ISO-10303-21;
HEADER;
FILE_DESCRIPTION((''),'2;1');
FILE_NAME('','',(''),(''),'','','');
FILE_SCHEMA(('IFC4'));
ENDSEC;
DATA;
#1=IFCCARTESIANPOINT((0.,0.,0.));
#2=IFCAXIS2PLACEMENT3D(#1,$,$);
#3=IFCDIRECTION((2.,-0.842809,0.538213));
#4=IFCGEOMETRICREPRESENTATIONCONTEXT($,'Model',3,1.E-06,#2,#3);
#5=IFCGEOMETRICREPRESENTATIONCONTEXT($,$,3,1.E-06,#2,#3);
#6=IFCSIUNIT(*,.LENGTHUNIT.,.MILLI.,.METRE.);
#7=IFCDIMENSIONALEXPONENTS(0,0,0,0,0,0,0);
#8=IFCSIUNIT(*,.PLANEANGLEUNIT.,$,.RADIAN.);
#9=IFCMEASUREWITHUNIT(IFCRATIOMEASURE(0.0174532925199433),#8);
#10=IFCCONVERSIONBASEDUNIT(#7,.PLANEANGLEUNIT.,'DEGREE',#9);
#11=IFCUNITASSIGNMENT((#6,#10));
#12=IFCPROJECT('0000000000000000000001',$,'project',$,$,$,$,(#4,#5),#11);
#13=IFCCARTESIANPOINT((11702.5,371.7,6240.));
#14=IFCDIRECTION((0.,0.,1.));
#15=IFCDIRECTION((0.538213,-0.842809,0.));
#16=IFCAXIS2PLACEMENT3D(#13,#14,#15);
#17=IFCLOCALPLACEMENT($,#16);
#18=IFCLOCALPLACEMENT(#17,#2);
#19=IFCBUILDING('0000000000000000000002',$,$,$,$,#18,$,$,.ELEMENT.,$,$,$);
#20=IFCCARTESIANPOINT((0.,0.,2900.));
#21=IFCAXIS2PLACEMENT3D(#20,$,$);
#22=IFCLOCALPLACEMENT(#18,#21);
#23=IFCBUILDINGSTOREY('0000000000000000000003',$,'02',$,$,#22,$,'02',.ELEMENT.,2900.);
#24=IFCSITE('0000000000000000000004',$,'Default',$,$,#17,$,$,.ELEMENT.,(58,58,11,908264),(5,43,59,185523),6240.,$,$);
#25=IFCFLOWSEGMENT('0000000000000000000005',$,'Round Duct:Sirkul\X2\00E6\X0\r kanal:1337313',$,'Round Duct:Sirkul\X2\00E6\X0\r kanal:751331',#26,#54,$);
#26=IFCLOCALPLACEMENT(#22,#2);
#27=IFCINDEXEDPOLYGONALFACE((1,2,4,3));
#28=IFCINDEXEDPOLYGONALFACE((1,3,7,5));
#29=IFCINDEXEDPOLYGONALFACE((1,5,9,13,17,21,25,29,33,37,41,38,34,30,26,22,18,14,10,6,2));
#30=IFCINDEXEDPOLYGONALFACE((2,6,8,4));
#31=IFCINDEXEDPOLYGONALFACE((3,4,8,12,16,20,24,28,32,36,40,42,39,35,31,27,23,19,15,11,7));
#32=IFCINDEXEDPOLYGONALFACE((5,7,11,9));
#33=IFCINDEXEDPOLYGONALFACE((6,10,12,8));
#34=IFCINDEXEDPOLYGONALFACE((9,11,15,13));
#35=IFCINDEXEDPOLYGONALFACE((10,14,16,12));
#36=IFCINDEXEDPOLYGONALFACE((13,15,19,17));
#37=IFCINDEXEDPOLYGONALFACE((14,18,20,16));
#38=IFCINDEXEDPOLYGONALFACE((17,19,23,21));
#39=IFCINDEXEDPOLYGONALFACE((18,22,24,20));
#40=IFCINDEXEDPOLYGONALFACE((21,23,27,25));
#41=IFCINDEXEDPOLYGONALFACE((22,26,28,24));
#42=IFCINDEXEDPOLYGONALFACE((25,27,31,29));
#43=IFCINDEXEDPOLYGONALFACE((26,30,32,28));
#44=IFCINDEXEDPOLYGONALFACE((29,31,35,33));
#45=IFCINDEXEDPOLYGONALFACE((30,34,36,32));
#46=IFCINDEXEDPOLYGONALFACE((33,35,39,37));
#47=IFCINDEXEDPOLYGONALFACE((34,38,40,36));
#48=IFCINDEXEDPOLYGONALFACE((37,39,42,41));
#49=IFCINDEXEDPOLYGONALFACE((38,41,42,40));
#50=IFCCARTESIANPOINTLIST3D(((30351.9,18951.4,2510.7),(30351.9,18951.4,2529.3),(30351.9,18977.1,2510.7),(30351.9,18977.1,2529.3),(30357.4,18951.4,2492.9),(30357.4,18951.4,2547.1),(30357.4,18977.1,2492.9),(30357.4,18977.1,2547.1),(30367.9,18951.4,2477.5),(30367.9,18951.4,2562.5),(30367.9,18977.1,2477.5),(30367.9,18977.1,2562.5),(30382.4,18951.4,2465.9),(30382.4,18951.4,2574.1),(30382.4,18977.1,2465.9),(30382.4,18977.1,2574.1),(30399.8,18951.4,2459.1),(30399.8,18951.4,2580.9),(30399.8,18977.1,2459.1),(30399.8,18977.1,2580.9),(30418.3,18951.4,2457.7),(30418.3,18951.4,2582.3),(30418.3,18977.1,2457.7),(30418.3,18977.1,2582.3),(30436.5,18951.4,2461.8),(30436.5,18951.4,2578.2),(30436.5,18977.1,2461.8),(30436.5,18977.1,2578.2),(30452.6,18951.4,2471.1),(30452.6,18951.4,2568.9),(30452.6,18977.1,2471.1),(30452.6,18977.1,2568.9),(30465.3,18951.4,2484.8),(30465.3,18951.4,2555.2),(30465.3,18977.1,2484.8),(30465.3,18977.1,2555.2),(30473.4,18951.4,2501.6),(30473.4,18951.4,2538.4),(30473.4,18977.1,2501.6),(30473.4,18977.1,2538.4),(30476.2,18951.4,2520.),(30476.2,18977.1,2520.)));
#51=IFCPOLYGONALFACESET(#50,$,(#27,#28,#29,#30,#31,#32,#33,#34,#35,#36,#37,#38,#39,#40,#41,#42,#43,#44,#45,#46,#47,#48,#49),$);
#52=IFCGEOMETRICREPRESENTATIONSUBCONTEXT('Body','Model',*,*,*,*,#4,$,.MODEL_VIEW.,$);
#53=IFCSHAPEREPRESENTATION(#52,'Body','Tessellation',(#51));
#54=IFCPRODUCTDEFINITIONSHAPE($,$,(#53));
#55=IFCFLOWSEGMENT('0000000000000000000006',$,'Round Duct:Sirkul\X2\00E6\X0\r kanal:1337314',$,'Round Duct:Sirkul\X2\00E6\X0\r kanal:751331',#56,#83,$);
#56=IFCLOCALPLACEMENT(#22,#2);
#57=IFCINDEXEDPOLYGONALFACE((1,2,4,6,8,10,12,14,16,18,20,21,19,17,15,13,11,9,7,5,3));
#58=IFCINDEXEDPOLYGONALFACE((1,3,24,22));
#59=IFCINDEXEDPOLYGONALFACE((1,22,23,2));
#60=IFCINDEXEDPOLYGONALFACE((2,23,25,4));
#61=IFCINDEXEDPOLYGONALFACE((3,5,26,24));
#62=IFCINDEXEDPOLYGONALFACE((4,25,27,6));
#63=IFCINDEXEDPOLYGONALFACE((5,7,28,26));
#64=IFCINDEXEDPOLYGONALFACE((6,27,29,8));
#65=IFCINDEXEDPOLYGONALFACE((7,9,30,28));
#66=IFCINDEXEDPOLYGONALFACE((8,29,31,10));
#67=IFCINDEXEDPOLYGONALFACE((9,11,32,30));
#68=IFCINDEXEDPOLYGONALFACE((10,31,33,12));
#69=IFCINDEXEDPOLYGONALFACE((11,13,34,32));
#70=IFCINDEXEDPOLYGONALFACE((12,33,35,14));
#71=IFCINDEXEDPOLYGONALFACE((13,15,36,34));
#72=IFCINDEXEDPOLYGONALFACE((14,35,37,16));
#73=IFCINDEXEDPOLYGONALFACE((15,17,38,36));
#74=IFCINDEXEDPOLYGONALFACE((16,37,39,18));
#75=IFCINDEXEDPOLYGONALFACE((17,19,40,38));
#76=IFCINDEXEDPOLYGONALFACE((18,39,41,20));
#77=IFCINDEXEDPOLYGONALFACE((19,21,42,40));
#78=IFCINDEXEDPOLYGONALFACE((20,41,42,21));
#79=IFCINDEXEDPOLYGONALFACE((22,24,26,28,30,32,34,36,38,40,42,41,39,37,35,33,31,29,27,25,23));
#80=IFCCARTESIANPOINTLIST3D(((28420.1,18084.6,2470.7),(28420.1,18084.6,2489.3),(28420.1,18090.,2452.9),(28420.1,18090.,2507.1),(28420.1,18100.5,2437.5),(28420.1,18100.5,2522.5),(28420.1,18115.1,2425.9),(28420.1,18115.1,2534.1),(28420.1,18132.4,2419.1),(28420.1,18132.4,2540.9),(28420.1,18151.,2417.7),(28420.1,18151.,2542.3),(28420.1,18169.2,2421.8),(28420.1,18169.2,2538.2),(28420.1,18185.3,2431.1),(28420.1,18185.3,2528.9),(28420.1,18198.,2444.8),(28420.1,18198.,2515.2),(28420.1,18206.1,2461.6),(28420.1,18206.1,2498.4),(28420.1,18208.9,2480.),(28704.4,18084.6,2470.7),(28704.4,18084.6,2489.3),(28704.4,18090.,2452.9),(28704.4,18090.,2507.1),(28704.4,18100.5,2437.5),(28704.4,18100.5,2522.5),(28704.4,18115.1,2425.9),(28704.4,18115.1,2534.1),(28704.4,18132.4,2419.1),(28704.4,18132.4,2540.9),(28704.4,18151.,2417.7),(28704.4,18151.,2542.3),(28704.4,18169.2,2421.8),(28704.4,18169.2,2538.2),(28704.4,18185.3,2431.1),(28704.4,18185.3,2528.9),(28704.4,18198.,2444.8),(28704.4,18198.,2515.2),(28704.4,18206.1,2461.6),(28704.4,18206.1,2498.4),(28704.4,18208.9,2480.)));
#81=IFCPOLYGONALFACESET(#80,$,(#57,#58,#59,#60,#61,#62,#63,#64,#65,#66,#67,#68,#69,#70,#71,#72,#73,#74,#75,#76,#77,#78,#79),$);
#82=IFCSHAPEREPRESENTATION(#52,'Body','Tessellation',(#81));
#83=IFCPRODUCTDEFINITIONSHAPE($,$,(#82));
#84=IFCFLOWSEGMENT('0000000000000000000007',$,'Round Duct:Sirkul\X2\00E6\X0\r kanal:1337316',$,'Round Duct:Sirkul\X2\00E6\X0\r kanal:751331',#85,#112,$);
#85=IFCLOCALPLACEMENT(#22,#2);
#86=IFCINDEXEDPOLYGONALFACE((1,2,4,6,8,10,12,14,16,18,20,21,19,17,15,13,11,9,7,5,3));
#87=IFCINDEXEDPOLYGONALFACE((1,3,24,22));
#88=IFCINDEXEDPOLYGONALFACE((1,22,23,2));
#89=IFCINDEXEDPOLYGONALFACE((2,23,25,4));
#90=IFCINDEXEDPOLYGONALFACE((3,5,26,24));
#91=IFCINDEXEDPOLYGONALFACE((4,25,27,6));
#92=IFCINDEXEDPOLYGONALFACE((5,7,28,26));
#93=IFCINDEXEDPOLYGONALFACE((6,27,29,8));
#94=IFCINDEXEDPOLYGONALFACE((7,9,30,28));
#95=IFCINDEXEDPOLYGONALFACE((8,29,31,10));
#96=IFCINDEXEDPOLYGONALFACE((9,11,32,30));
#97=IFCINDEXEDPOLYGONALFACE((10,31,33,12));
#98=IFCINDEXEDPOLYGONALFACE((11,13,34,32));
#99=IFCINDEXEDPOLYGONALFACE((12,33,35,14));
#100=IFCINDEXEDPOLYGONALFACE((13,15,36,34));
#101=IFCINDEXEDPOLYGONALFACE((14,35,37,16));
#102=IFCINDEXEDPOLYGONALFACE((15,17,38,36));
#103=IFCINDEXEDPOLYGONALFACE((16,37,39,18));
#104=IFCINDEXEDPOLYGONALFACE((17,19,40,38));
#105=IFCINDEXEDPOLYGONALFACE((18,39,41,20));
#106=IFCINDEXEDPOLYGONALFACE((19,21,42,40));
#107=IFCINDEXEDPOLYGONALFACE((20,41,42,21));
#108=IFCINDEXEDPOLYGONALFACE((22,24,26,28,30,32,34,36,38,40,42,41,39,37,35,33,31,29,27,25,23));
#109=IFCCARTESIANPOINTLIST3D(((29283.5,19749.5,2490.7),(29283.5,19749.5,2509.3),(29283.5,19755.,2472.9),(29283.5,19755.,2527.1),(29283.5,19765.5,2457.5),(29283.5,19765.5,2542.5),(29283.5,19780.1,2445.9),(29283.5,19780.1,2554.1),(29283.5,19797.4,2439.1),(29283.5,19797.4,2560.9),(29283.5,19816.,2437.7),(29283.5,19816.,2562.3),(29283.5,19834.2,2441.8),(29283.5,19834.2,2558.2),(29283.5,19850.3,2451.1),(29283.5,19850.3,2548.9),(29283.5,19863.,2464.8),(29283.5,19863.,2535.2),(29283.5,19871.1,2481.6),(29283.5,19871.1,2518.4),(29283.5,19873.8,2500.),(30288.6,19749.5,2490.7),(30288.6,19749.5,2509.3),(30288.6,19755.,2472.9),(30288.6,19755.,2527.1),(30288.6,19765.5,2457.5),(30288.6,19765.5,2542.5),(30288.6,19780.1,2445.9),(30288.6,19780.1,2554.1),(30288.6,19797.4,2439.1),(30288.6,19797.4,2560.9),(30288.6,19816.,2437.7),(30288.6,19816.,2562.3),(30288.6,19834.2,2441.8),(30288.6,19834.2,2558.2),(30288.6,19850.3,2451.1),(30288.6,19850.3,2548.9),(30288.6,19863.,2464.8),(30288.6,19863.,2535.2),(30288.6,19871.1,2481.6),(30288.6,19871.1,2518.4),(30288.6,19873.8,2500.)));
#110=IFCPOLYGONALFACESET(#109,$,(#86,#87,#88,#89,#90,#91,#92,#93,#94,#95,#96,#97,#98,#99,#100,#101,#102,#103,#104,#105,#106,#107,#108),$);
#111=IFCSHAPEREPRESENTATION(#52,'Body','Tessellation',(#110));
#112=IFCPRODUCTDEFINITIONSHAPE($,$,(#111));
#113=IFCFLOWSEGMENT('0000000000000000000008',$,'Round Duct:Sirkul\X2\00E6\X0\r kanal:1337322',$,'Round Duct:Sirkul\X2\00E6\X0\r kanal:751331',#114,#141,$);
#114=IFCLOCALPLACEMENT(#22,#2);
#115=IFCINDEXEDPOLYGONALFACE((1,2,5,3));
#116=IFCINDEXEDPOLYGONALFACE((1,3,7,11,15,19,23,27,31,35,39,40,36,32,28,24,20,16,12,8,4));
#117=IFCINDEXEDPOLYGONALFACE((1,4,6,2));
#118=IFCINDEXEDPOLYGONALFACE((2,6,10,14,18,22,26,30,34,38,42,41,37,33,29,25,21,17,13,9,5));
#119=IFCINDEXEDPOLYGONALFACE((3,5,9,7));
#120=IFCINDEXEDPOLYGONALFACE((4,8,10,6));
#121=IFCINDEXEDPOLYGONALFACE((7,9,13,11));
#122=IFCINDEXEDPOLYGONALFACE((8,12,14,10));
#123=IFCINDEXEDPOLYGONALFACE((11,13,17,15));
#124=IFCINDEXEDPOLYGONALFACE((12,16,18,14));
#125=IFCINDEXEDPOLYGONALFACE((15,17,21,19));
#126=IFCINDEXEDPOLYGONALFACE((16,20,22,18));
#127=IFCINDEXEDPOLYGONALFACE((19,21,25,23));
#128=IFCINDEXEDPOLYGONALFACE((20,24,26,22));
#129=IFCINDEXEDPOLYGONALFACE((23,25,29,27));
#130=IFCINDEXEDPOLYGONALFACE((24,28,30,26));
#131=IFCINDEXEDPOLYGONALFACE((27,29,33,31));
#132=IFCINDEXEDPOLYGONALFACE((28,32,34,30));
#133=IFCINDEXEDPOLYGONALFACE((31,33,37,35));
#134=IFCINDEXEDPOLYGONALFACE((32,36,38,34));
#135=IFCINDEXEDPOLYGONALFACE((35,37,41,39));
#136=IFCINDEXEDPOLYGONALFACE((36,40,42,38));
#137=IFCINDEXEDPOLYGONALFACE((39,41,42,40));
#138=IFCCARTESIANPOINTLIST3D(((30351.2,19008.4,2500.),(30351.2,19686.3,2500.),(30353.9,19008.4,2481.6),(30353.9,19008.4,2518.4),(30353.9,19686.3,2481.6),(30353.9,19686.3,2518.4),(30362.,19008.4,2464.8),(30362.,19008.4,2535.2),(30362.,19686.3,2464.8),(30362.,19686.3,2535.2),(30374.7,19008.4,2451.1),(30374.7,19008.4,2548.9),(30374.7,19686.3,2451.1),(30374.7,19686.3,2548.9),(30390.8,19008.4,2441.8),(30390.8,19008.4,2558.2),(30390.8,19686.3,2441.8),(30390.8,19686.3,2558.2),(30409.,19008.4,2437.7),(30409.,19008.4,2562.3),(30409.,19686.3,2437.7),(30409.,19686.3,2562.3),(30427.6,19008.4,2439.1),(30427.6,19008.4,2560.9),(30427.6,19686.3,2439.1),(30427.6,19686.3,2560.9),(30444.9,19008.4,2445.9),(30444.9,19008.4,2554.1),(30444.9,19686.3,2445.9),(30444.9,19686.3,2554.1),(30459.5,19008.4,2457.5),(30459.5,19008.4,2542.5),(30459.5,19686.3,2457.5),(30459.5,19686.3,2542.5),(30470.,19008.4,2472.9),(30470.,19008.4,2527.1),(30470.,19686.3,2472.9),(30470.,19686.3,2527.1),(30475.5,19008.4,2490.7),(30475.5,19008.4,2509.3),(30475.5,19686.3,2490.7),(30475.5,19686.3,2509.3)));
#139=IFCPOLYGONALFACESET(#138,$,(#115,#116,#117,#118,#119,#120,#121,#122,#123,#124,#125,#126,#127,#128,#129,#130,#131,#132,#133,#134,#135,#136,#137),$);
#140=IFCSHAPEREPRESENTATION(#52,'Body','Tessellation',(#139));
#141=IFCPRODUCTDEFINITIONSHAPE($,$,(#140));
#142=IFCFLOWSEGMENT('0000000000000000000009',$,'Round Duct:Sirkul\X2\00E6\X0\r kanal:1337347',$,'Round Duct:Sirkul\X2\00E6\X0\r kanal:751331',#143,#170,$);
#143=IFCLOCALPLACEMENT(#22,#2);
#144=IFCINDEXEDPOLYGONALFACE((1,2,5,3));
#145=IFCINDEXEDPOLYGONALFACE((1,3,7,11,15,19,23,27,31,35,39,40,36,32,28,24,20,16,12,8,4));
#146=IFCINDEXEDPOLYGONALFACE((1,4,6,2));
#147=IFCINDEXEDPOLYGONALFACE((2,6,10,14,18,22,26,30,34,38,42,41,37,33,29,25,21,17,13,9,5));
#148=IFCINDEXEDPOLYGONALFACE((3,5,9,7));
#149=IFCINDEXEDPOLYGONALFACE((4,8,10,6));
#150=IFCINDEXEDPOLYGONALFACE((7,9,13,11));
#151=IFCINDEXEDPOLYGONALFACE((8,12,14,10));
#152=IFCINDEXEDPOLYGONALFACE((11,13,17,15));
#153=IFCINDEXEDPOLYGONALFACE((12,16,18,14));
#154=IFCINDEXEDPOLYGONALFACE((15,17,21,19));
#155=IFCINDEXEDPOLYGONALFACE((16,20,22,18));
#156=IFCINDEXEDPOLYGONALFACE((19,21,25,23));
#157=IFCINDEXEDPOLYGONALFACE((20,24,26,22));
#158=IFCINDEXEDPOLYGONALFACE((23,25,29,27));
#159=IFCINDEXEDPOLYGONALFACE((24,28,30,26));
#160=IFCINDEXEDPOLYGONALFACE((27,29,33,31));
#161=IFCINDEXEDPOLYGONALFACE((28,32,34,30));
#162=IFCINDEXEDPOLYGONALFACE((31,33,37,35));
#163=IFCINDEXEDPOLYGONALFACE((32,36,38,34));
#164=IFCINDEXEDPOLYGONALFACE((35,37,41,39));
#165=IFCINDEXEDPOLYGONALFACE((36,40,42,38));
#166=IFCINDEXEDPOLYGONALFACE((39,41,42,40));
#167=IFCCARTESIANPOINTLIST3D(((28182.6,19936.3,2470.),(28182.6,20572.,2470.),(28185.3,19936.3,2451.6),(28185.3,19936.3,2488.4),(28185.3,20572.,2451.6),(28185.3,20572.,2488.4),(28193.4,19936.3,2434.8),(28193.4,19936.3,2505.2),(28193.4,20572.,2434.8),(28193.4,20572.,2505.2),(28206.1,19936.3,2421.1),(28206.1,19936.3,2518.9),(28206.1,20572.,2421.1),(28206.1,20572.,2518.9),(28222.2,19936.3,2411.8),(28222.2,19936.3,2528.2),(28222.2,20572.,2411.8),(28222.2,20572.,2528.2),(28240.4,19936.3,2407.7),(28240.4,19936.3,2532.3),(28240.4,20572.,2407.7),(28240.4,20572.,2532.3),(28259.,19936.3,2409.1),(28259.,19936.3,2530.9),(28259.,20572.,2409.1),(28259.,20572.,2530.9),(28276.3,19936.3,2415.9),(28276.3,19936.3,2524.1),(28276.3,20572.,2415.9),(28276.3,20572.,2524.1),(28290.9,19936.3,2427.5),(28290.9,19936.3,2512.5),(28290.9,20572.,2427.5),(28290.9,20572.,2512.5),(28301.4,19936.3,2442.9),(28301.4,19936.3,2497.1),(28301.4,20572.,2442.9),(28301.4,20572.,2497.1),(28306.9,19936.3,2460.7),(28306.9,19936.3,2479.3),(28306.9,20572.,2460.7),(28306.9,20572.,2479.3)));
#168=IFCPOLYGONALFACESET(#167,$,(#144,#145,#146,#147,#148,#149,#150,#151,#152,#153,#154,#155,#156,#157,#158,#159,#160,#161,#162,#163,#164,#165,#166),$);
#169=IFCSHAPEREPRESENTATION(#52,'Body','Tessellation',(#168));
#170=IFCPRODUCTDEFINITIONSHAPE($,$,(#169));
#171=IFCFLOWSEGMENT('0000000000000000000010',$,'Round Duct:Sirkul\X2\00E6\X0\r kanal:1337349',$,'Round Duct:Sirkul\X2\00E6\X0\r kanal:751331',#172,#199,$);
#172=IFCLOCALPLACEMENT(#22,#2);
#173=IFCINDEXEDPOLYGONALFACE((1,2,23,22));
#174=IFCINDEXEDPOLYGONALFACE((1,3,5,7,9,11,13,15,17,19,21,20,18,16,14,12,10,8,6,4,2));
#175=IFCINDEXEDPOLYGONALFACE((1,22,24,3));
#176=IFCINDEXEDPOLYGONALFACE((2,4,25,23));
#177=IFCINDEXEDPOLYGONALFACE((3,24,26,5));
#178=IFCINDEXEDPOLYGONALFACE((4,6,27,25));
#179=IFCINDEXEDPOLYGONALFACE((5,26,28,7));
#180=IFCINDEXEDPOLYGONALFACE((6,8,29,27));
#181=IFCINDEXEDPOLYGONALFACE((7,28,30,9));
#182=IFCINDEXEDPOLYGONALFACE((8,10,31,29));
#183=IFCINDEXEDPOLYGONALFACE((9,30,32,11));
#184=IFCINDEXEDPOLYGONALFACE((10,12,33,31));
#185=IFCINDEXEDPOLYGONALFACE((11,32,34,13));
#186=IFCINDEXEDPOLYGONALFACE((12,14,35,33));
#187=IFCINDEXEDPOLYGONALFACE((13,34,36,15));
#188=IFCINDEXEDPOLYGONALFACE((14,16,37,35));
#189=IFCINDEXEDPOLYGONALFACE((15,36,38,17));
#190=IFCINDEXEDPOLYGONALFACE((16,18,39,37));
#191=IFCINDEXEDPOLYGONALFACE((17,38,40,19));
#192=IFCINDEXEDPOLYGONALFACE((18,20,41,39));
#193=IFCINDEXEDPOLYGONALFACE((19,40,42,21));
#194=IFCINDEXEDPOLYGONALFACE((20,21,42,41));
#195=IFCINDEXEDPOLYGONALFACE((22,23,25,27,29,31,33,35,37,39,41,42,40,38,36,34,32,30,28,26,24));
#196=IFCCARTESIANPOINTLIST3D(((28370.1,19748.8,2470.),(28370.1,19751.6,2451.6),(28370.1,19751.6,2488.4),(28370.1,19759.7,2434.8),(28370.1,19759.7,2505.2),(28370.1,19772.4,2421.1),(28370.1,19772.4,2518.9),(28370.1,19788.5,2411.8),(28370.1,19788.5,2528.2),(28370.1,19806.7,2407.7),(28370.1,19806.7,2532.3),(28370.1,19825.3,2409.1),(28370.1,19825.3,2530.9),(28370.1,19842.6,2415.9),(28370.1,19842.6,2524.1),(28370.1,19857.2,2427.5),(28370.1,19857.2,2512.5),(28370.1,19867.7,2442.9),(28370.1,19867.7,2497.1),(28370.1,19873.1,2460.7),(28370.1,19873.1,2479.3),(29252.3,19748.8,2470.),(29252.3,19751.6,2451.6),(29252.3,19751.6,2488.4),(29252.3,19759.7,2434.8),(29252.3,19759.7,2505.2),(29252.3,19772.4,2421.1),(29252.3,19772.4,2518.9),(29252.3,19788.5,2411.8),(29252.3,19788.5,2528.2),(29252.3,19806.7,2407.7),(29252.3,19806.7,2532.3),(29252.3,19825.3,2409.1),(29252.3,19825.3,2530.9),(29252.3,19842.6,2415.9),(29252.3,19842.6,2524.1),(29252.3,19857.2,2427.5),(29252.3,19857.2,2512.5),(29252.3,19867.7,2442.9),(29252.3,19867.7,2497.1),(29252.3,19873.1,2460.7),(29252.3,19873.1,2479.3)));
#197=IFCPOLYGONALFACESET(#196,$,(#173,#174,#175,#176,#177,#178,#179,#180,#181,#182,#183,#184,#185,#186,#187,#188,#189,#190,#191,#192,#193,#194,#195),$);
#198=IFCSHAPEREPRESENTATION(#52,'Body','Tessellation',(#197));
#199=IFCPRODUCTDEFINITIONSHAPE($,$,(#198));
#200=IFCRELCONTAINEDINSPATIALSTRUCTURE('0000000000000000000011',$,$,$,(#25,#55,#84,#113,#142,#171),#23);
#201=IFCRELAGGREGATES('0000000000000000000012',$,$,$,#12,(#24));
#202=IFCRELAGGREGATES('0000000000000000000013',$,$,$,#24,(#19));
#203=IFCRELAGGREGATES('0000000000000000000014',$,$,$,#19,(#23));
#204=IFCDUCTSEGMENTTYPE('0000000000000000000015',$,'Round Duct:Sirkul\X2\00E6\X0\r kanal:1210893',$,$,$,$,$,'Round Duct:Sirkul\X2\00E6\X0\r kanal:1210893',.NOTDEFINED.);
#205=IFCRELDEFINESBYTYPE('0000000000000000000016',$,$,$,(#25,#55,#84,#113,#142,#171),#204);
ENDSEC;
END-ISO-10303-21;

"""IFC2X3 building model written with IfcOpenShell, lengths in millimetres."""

from ifc_helpers import new_model, entity, si_unit, converted_unit, direction, frame, origin, origin_2d_with_axis, place, context, subcontext, project, spatial, circle, extrude, type_object, element, save


model = new_model("IFC2X3")

# Units and contexts
model_context = context("Model", 3, precision=1e-06, world=origin(), true_north=direction((2.0, -0.842809, 0.538213)))
context_of_model = context(None, 3, precision=1e-06, world=origin(), true_north=direction((2.0, -0.842809, 0.538213)))
body_context = subcontext(model_context, "Body", "Model", "MODEL_VIEW")
ifc_project = project(units=[si_unit("LENGTHUNIT", "METRE", prefix="MILLI"), converted_unit("PLANEANGLEUNIT", "DEGREE", entity("IfcRatioMeasure", 0.0174532925199433), si_unit("PLANEANGLEUNIT", "RADIAN"), dimensions=[0, 0, 0, 0, 0, 0, 0])], contexts=[model_context, context_of_model])

# Site, building, storey
site_placement = place(None, frame((11702.5, 371.7, 6240.0), z_axis=(0.0, 0.0, 1.0), x_axis=(0.538213, -0.842809, 0.0)))
site = spatial("IfcSite", under=ifc_project, at=site_placement, Name="Default", CompositionType="ELEMENT", RefLatitude=(58, 58, 11, 908264), RefLongitude=(5, 43, 59, 185523), RefElevation=6240.0)
building_placement = place(site_placement, origin())
building = spatial("IfcBuilding", under=site, at=building_placement, CompositionType="ELEMENT")
storey_placement = place(building_placement, frame((0.0, 0.0, 2900.0)))
storey = spatial("IfcBuildingStorey", under=building, at=storey_placement, Name="02", LongName="02", CompositionType="ELEMENT", Elevation=2900.0)

# Flow segments
duct_segment_type_1 = type_object("IfcDuctSegmentType", Name="Round Duct:Sirkulær kanal:1210893", ElementType="Round Duct:Sirkulær kanal:1210893", PredefinedType="NOTDEFINED")
flow_segment_1_placement = place(storey_placement, origin())
element("IfcFlowSegment", 1, at=flow_segment_1_placement, inside=storey, type_object=duct_segment_type_1, Name="Round Duct:Sirkulær kanal:1337313", ObjectType="Round Duct:Sirkulær kanal:751331", context=body_context, shape_type="SweptSolid", body=[
    extrude(circle(Radius=62.5, at=origin_2d_with_axis()), frame((30413.7, 18951.4, 2520.0), z_axis=(0.0, 1.0, 0.0), x_axis=(1.0, 0.0, 0.0)), (0.0, 0.0, 1.0), 25.7),
])
flow_segment_2_placement = place(storey_placement, origin())
element("IfcFlowSegment", 2, at=flow_segment_2_placement, inside=storey, type_object=duct_segment_type_1, Name="Round Duct:Sirkulær kanal:1337314", ObjectType="Round Duct:Sirkulær kanal:751331", context=body_context, shape_type="SweptSolid", body=[
    extrude(circle(Radius=62.5, at=origin_2d_with_axis()), frame((28420.1, 18146.4, 2480.0), z_axis=(1.0, 0.0, 0.0), x_axis=(0.0, 1.0, 0.0)), (0.0, 0.0, 1.0), 284.4),
])
flow_segment_3_placement = place(storey_placement, origin())
element("IfcFlowSegment", 3, at=flow_segment_3_placement, inside=storey, type_object=duct_segment_type_1, Name="Round Duct:Sirkulær kanal:1337316", ObjectType="Round Duct:Sirkulær kanal:751331", context=body_context, shape_type="SweptSolid", body=[
    extrude(circle(Radius=62.5, at=origin_2d_with_axis()), frame((29283.5, 19811.3, 2500.0), z_axis=(1.0, 0.0, 0.0), x_axis=(0.0, 1.0, 0.0)), (0.0, 0.0, 1.0), 1005.1),
])
flow_segment_4_placement = place(storey_placement, origin())
element("IfcFlowSegment", 4, at=flow_segment_4_placement, inside=storey, type_object=duct_segment_type_1, Name="Round Duct:Sirkulær kanal:1337322", ObjectType="Round Duct:Sirkulær kanal:751331", context=body_context, shape_type="SweptSolid", body=[
    extrude(circle(Radius=62.5, at=origin_2d_with_axis()), frame((30413.7, 19008.4, 2500.0), z_axis=(0.0, 1.0, 0.0), x_axis=(-1.0, 0.0, 0.0)), (0.0, 0.0, 1.0), 677.9),
])
flow_segment_5_placement = place(storey_placement, origin())
element("IfcFlowSegment", 5, at=flow_segment_5_placement, inside=storey, type_object=duct_segment_type_1, Name="Round Duct:Sirkulær kanal:1337347", ObjectType="Round Duct:Sirkulær kanal:751331", context=body_context, shape_type="SweptSolid", body=[
    extrude(circle(Radius=62.5, at=origin_2d_with_axis()), frame((28245.1, 19936.3, 2470.0), z_axis=(0.0, 1.0, 0.0), x_axis=(-1.0, 0.0, 0.0)), (0.0, 0.0, 1.0), 635.7),
])
flow_segment_6_placement = place(storey_placement, origin())
element("IfcFlowSegment", 6, at=flow_segment_6_placement, inside=storey, type_object=duct_segment_type_1, Name="Round Duct:Sirkulær kanal:1337349", ObjectType="Round Duct:Sirkulær kanal:751331", context=body_context, shape_type="SweptSolid", body=[
    extrude(circle(Radius=62.5, at=origin_2d_with_axis()), frame((28370.1, 19811.3, 2470.0), z_axis=(1.0, 0.0, 0.0), x_axis=(0.0, -1.0, 0.0)), (0.0, 0.0, 1.0), 882.2),
])

save(model, "model.ifc")
